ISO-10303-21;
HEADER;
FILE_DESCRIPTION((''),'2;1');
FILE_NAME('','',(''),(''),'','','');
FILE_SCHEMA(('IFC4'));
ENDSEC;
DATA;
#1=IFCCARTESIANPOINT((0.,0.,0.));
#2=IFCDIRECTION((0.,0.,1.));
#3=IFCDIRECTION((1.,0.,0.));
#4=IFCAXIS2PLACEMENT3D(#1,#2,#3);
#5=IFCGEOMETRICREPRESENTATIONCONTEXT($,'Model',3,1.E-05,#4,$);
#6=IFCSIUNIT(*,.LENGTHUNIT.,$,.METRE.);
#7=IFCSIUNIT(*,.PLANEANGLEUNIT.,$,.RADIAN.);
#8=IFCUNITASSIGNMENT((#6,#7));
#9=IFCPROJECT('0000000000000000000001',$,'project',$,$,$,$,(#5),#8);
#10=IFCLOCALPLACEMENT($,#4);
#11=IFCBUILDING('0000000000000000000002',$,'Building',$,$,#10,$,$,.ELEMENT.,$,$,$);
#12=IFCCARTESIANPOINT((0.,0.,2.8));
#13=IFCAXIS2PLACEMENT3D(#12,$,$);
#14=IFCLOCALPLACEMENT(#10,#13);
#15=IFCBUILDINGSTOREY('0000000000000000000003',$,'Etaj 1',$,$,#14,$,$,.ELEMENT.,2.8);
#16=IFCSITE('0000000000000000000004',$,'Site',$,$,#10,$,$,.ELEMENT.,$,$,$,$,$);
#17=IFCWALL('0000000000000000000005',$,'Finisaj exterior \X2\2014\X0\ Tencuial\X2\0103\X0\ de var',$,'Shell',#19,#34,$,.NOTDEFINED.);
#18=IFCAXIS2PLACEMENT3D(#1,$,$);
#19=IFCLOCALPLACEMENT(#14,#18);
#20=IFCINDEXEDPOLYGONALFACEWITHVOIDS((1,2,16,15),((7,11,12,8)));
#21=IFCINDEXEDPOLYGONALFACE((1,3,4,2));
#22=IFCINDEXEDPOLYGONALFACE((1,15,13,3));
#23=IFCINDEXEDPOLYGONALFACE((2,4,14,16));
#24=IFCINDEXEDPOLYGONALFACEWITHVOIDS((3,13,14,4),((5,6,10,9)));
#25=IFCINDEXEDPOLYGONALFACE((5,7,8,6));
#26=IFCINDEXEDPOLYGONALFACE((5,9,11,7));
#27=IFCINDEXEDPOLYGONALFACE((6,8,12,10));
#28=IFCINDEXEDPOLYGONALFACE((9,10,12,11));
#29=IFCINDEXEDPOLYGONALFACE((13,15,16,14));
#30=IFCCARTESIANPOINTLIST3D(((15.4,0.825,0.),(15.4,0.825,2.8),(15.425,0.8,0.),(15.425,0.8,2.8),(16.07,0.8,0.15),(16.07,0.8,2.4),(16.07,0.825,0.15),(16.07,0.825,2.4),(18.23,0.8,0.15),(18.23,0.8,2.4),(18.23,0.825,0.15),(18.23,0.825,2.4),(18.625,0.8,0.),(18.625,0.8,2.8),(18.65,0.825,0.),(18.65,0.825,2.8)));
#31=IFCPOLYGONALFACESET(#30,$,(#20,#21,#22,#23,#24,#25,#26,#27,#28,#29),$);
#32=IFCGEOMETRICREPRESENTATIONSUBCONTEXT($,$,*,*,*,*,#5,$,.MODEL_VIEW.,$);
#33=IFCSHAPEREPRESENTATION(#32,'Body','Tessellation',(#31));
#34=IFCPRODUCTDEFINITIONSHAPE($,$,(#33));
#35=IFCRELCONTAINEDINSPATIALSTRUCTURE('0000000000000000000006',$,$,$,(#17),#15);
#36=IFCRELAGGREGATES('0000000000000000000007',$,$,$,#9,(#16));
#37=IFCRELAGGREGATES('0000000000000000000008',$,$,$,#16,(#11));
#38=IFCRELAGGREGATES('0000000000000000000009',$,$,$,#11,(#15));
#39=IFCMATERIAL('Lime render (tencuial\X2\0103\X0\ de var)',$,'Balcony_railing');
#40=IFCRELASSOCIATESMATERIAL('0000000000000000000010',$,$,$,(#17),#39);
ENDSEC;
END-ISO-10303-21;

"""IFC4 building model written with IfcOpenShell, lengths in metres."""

from ifc_helpers import new_model, si_unit, frame, origin, origin_with_axes, origin_2d, place, context, subcontext, project, spatial, polyline, rectangle, outline, extrude, material, element, save


model = new_model("IFC4")

# Units and contexts
model_context = context("Model", 3, precision=1e-05, world=origin_with_axes())
sub_context = subcontext(model_context, None, None, "MODEL_VIEW")
ifc_project = project(units=[si_unit("LENGTHUNIT", "METRE"), si_unit("PLANEANGLEUNIT", "RADIAN")], contexts=[model_context])

# Site, building, storey
placement = place(None, origin_with_axes())
site = spatial("IfcSite", under=ifc_project, at=placement, Name="Site", CompositionType="ELEMENT")
building = spatial("IfcBuilding", under=site, at=placement, Name="Building", CompositionType="ELEMENT")
storey_placement = place(placement, frame((0.0, 0.0, 2.8)))
storey = spatial("IfcBuildingStorey", under=building, at=storey_placement, Name="Etaj 1", CompositionType="ELEMENT", Elevation=2.8)

# Shared definitions
ifc_material = material(Name="Lime render (tencuială de var)", Category="Balcony_railing")

# Wall, opening
wall_1_placement = place(storey_placement, origin_with_axes())
wall_1 = element("IfcWall", 1, at=wall_1_placement, inside=storey, material=ifc_material, Name="Finisaj exterior — Tencuială de var", ObjectType="Shell", PredefinedType="NOTDEFINED", context=sub_context, shape_type="SweptSolid", body=[
    extrude(outline(polyline([(15.425, 0.8), (18.625, 0.8), (18.65, 0.825), (15.4, 0.825), (15.425, 0.8)])), origin(), (0.0, 0.0, 1.0), 2.8),
])
opening_1_placement = place(wall_1_placement, frame((17.15, 1.25, 0.15), z_axis=(0.0, -1.0, 0.0), x_axis=(1.0, 0.0, 0.0)))
element("IfcOpeningElement", 2, at=opening_1_placement, cuts=wall_1, PredefinedType="OPENING", context=sub_context, shape_type="SweptSolid", body=[
    extrude(rectangle(XDim=2.16, YDim=2.25, at=origin_2d()), frame((0.0, 1.125, 0.0)), (0.0, 0.0, 1.0), 0.5),
])

save(model, "model.ifc")
